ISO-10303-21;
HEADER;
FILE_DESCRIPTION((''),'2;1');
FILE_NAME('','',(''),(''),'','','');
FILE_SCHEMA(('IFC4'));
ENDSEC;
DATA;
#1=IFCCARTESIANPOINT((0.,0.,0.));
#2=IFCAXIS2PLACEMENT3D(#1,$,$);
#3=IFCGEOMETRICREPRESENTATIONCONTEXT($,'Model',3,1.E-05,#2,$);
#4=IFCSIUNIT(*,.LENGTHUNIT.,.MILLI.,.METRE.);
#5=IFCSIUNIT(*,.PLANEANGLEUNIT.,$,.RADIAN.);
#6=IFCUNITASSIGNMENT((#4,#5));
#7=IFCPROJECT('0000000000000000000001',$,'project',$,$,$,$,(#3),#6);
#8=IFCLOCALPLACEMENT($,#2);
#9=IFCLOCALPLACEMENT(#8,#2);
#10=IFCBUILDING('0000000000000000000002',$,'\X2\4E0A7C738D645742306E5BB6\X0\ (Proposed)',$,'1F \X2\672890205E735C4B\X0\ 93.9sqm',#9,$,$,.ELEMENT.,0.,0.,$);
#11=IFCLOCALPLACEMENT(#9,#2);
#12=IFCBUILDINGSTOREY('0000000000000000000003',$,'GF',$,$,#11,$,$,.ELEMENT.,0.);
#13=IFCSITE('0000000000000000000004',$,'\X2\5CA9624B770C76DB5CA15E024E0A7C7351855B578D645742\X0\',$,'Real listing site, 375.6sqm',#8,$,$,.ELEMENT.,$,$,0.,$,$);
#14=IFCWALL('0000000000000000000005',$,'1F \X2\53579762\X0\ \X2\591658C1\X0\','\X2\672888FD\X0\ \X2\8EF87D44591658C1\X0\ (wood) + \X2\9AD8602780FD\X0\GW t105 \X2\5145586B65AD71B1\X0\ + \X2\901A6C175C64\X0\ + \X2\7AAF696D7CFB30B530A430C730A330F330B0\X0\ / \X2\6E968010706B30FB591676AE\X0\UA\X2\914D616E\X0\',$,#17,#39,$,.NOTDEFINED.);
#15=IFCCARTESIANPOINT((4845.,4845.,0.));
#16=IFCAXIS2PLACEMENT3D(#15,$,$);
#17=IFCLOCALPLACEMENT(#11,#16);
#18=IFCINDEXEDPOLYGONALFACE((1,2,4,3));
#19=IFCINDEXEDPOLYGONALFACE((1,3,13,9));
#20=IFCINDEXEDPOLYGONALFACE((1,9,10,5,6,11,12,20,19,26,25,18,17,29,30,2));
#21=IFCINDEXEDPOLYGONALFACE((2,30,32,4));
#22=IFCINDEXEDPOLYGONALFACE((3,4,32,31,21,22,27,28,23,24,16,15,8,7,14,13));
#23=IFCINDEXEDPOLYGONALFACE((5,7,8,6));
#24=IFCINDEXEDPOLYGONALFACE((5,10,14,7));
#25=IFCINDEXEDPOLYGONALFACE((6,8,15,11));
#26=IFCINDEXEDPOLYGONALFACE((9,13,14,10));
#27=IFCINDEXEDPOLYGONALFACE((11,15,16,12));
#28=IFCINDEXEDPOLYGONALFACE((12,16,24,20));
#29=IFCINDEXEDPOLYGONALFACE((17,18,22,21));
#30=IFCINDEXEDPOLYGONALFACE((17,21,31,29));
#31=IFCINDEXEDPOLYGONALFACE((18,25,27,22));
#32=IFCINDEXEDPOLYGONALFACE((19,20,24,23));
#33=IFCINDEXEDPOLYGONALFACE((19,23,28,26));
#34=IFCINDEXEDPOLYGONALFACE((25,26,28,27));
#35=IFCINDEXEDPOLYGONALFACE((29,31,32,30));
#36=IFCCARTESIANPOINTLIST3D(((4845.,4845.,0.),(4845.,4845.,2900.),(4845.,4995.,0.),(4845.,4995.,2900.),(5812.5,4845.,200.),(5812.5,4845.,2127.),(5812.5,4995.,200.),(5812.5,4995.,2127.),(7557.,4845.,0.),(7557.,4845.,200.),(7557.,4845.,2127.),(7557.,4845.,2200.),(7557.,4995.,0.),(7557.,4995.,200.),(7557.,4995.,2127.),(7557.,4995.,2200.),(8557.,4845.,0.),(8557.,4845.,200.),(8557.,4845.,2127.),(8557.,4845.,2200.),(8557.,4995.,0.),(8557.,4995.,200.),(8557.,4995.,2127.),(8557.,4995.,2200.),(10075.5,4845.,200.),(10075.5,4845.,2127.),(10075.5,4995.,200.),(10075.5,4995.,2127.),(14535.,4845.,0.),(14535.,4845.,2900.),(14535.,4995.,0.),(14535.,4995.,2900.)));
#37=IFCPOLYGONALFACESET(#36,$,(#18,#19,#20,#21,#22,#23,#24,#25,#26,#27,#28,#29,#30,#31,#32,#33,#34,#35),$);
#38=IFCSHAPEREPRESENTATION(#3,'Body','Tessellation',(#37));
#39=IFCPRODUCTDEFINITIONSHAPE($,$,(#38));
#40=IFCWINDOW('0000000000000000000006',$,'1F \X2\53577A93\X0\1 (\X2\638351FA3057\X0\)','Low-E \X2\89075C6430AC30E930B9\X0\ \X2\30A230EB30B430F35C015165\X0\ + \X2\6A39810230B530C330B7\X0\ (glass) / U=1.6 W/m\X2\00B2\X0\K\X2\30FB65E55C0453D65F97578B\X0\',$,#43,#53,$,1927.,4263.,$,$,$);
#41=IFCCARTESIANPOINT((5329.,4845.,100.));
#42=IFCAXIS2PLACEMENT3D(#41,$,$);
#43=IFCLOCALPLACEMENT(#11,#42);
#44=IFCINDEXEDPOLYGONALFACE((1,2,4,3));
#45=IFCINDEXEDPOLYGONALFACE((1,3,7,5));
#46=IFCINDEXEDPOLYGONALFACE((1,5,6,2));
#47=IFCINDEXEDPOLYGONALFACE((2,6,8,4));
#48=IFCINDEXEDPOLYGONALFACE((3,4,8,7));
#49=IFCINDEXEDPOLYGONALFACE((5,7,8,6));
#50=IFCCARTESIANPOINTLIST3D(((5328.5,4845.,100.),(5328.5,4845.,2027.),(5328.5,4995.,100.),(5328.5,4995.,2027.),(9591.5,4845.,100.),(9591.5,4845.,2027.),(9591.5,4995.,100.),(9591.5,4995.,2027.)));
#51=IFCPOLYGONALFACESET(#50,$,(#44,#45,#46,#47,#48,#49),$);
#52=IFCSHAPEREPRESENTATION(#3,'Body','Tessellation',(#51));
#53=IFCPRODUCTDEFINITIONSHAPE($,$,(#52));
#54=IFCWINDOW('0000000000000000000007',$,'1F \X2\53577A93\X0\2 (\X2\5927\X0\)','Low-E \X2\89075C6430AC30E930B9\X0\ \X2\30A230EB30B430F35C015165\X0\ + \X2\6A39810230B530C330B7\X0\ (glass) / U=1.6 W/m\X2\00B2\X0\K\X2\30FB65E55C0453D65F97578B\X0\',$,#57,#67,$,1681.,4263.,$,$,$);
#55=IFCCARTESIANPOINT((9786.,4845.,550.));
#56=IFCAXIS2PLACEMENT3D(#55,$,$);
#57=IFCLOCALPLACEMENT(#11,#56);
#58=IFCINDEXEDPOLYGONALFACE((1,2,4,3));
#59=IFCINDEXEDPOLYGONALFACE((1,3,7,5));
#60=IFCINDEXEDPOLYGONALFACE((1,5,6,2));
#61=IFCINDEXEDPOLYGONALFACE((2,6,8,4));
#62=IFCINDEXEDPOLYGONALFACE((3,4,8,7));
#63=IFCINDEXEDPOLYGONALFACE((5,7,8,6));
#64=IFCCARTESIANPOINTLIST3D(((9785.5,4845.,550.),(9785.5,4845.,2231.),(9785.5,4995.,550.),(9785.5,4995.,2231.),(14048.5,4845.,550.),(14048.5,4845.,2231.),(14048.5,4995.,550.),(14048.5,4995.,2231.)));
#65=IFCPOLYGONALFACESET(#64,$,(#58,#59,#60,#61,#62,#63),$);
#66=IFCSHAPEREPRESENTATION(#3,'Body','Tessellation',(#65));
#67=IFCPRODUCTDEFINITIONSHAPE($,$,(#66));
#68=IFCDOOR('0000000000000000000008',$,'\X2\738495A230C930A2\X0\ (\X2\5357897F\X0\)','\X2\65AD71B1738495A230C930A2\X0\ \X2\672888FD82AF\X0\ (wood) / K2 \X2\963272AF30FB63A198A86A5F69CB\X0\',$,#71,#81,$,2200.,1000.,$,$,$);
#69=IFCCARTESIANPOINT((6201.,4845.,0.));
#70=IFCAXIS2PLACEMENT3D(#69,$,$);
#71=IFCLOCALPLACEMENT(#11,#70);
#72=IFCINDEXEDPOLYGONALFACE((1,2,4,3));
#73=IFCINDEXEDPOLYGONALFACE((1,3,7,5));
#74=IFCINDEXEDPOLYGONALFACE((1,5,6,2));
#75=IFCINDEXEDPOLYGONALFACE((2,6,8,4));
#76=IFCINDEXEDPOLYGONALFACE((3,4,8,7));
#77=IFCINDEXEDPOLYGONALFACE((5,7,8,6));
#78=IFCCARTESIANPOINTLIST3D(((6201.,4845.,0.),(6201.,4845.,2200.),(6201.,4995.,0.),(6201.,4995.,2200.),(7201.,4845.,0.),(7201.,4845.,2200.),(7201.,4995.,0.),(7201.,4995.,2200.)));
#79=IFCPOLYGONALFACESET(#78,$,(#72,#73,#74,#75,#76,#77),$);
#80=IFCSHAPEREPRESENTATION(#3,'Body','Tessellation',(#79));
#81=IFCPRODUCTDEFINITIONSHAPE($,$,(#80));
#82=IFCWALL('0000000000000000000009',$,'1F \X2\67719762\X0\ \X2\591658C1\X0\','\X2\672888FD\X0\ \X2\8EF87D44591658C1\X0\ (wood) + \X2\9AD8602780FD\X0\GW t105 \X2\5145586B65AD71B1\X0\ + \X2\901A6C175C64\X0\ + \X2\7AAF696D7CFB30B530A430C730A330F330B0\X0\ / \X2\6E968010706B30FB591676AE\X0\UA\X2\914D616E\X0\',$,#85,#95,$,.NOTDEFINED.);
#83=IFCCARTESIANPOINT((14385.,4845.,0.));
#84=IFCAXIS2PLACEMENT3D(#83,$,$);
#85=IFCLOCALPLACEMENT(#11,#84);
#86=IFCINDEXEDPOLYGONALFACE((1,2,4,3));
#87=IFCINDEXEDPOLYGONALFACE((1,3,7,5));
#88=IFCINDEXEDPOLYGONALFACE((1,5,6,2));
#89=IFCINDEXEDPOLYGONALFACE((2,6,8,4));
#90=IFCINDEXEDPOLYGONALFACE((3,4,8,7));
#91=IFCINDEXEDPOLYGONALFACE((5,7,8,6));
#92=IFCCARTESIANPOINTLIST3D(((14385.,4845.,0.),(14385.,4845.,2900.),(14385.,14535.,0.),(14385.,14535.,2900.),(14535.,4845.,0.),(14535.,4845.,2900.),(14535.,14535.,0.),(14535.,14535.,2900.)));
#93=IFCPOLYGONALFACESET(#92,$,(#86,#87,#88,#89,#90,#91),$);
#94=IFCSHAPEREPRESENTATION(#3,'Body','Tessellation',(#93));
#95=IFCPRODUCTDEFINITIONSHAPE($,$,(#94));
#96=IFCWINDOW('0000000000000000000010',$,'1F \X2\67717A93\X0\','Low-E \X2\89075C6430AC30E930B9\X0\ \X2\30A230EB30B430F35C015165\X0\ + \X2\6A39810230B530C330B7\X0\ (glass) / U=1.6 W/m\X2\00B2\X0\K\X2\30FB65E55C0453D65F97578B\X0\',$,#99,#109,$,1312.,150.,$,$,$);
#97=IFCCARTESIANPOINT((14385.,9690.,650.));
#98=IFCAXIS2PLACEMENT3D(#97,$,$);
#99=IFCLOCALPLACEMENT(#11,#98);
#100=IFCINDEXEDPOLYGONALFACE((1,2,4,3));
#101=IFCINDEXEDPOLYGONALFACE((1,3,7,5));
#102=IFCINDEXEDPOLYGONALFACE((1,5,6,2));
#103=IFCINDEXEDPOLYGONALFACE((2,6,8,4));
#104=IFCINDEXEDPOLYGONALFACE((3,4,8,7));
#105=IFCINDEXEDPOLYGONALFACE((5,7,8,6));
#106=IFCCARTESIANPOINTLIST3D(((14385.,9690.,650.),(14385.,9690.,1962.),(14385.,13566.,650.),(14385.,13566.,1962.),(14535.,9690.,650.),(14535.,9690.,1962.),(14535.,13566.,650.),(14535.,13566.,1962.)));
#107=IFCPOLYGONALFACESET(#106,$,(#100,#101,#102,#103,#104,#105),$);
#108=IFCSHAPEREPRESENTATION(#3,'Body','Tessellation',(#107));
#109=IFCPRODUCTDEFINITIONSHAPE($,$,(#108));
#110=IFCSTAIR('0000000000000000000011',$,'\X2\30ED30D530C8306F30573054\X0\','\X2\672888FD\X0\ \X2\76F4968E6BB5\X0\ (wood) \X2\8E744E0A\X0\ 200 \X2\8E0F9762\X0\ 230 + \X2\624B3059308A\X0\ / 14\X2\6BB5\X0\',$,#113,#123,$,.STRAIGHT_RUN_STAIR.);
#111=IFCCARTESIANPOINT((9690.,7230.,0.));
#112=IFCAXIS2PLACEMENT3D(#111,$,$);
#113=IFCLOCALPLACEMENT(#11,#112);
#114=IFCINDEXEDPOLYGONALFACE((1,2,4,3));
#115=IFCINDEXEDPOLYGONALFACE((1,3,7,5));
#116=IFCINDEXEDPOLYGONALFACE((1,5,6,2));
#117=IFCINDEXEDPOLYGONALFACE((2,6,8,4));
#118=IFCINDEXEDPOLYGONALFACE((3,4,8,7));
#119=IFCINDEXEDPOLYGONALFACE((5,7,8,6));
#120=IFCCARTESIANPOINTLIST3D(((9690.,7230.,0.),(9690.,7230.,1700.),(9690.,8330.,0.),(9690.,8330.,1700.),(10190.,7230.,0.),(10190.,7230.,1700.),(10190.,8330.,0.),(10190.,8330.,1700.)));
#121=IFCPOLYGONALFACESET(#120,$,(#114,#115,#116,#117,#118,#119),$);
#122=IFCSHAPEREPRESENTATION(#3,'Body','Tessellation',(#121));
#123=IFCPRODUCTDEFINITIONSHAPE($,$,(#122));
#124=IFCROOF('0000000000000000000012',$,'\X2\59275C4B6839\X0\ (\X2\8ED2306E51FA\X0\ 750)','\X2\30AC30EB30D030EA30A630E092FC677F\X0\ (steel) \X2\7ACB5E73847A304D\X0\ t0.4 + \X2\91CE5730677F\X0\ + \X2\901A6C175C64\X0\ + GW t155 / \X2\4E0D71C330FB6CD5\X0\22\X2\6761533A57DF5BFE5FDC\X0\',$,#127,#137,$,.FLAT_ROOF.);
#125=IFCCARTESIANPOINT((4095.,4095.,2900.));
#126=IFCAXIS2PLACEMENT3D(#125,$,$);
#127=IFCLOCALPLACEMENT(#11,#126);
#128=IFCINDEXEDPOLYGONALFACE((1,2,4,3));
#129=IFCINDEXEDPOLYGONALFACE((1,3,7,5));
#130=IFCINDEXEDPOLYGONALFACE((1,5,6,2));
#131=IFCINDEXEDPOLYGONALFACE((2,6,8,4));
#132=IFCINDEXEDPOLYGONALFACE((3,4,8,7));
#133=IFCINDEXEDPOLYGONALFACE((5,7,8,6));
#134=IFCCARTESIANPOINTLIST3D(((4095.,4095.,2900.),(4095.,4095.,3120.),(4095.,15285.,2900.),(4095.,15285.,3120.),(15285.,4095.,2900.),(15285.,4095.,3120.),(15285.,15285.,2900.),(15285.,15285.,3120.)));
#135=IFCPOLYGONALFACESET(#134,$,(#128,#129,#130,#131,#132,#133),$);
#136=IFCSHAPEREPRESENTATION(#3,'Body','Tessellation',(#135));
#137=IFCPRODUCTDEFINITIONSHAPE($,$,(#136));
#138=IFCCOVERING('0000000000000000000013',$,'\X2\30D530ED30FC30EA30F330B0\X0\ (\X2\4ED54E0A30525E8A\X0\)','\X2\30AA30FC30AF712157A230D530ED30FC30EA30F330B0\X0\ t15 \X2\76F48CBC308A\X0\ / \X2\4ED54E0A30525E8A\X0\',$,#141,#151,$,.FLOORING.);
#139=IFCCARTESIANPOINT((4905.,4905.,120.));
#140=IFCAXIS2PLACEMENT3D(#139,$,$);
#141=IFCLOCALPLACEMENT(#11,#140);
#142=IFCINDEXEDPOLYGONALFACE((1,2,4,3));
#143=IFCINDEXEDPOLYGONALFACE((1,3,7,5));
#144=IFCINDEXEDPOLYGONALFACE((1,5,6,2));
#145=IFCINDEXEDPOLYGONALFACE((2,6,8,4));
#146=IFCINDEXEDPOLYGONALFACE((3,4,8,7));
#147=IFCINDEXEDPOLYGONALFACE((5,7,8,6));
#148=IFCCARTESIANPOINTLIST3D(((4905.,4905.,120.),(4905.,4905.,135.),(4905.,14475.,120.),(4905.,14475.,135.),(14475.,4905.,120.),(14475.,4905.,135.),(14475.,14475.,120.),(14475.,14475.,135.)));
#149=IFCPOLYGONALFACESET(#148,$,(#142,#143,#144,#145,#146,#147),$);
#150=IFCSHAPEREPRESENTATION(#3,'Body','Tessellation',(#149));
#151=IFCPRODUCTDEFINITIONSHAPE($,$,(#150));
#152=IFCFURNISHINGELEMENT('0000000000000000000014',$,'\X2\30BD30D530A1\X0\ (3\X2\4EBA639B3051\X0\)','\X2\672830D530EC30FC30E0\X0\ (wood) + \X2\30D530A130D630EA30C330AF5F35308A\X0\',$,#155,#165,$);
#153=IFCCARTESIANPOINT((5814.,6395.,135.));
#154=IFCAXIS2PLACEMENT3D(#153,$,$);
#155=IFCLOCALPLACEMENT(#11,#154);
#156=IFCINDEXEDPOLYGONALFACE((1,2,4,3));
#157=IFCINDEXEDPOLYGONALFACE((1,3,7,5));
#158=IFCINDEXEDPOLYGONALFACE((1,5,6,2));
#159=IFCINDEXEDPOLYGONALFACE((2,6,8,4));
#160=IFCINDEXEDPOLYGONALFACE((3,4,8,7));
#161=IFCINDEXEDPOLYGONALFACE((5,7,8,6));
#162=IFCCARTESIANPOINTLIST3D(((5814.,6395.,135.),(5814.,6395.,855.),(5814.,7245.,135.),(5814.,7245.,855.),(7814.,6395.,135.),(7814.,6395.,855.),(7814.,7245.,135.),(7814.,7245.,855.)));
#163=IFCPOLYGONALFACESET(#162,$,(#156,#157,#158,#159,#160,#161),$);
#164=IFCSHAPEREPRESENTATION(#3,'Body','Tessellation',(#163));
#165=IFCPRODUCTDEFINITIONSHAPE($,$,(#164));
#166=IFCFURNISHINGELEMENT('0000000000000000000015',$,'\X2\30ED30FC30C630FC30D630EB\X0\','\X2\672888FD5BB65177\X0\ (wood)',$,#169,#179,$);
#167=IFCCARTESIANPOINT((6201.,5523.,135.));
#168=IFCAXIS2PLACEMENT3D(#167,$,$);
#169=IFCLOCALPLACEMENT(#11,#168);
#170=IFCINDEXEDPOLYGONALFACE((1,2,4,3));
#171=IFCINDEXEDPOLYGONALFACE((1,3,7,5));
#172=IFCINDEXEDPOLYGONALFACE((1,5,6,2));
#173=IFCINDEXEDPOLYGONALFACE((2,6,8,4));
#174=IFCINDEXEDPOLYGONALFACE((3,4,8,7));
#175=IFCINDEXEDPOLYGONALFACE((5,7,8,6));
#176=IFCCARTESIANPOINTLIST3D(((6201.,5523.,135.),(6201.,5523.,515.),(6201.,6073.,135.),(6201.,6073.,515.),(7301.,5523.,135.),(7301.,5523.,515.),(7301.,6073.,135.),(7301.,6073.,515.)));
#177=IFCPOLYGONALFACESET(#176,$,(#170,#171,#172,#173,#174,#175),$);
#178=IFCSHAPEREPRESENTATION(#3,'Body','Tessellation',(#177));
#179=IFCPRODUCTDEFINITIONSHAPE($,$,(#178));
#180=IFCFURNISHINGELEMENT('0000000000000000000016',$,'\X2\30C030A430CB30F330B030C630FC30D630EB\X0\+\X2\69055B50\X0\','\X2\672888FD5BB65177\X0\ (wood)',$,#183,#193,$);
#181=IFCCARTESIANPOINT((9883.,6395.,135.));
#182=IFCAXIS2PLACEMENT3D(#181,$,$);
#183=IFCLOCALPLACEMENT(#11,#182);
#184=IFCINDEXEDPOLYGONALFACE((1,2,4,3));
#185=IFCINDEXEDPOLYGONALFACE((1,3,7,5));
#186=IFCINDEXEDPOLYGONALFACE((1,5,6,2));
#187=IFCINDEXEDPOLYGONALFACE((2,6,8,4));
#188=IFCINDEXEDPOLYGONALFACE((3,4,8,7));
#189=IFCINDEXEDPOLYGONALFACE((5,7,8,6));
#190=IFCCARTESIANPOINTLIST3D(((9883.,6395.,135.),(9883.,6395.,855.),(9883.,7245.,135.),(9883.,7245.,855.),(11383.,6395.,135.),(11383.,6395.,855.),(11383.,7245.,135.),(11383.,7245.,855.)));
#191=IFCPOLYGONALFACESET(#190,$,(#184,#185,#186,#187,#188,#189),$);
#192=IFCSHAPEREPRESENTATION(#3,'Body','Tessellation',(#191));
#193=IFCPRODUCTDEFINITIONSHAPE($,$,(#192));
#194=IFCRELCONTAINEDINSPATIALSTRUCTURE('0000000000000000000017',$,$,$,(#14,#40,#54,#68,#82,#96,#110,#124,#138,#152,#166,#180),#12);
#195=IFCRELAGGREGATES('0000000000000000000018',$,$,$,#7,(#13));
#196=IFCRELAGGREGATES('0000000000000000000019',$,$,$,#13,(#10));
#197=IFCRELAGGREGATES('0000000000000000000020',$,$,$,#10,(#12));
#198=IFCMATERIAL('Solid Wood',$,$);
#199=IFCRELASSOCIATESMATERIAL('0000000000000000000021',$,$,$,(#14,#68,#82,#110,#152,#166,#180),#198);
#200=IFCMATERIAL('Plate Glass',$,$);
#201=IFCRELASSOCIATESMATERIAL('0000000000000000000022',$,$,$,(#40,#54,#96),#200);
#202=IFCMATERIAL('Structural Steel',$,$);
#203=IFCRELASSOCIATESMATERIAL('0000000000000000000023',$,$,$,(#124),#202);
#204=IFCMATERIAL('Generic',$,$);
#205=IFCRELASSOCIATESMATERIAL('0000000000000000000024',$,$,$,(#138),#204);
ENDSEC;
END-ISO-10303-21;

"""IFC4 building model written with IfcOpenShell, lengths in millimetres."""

from ifc_helpers import new_model, si_unit, frame, frame_2d, origin, place, context, project, spatial, rectangle, extrude, material, element, fill, save


model = new_model("IFC4")

# Units and contexts
model_context = context("Model", 3, precision=1e-05, world=origin())
ifc_project = project(units=[si_unit("LENGTHUNIT", "METRE", prefix="MILLI"), si_unit("PLANEANGLEUNIT", "RADIAN")], contexts=[model_context])

# Site, building, storey
site_placement = place(None, origin())
site = spatial("IfcSite", under=ifc_project, at=site_placement, Name="岩手県盛岡市上米内字赤坂", ObjectType="Real listing site, 375.6sqm", CompositionType="ELEMENT", RefElevation=0.0)
building_placement = place(site_placement, origin())
building = spatial("IfcBuilding", under=site, at=building_placement, Name="上米赤坂の家 (Proposed)", ObjectType="1F 木造平屋 93.9sqm", CompositionType="ELEMENT", ElevationOfRefHeight=0.0, ElevationOfTerrain=0.0)
storey_placement = place(building_placement, origin())
storey = spatial("IfcBuildingStorey", under=building, at=storey_placement, Name="GF", CompositionType="ELEMENT", Elevation=0.0)

# Shared definitions
ifc_material_1 = material(Name="Solid Wood")

# Wall, openings, windows, door
wall_1_placement = place(storey_placement, frame((4845.0, 4845.0, 0.0)))
wall_1 = element("IfcWall", 1, at=wall_1_placement, inside=storey, material=ifc_material_1, Name="1F 南面 外壁", Description="木製 軸組外壁 (wood) + 高性能GW t105 充填断熱 + 通気層 + 窯業系サイディング / 準耐火・外皮UA配慮", PredefinedType="NOTDEFINED", context=model_context, shape_type="SweptSolid", body=[
    extrude(rectangle(XDim=9690.0, YDim=150.0, at=frame_2d((4845.0, 75.0))), frame((4845.0, 4845.0, 0.0)), (0.0, 0.0, 1.0), 2900.0),
])
opening_1_placement = place(storey_placement, frame((5329.0, 4845.0, 100.0)))
opening_1 = element("IfcOpeningElement", 2, at=opening_1_placement, cuts=wall_1, PredefinedType="NOTDEFINED", context=model_context, shape_type="SweptSolid", body=[
    extrude(rectangle(XDim=4263.0, YDim=150.0, at=frame_2d((2131.0, 75.0))), frame((5329.0, 4845.0, 100.0)), (0.0, 0.0, 1.0), 1927.0),
])
opening_2_placement = place(storey_placement, frame((9786.0, 4845.0, 550.0)))
opening_2 = element("IfcOpeningElement", 3, at=opening_2_placement, cuts=wall_1, PredefinedType="NOTDEFINED", context=model_context, shape_type="SweptSolid", body=[
    extrude(rectangle(XDim=4263.0, YDim=150.0, at=frame_2d((2131.0, 75.0))), frame((9786.0, 4845.0, 550.0)), (0.0, 0.0, 1.0), 1681.0),
])
opening_3_placement = place(storey_placement, frame((6201.0, 4845.0, 0.0)))
opening_3 = element("IfcOpeningElement", 4, at=opening_3_placement, cuts=wall_1, PredefinedType="NOTDEFINED", context=model_context, shape_type="SweptSolid", body=[
    extrude(rectangle(XDim=1000.0, YDim=150.0, at=frame_2d((500.0, 75.0))), frame((6201.0, 4845.0, 0.0)), (0.0, 0.0, 1.0), 2200.0),
])
ifc_material_2 = material(Name="Plate Glass")
window_1_placement = place(storey_placement, frame((5329.0, 4845.0, 100.0)))
window_1 = element("IfcWindow", 5, at=window_1_placement, inside=storey, material=ifc_material_2, Name="1F 南窓1 (掃出し)", Description="Low-E 複層ガラス アルゴン封入 + 樹脂サッシ (glass) / U=1.6 W/m²K・日射取得型", OverallHeight=1927.0, OverallWidth=4263.0, context=model_context, shape_type="SweptSolid", body=[
    extrude(rectangle(XDim=4263.0, YDim=150.0, at=frame_2d((2131.0, 75.0))), frame((5329.0, 4845.0, 100.0)), (0.0, 0.0, 1.0), 1927.0),
])
fill(opening_1, window_1)
window_2_placement = place(storey_placement, frame((9786.0, 4845.0, 550.0)))
window_2 = element("IfcWindow", 6, at=window_2_placement, inside=storey, material=ifc_material_2, Name="1F 南窓2 (大)", Description="Low-E 複層ガラス アルゴン封入 + 樹脂サッシ (glass) / U=1.6 W/m²K・日射取得型", OverallHeight=1681.0, OverallWidth=4263.0, context=model_context, shape_type="SweptSolid", body=[
    extrude(rectangle(XDim=4263.0, YDim=150.0, at=frame_2d((2131.0, 75.0))), frame((9786.0, 4845.0, 550.0)), (0.0, 0.0, 1.0), 1681.0),
])
fill(opening_2, window_2)
door_placement = place(storey_placement, frame((6201.0, 4845.0, 0.0)))
door = element("IfcDoor", 7, at=door_placement, inside=storey, material=ifc_material_1, Name="玄関ドア (南西)", Description="断熱玄関ドア 木製芯 (wood) / K2 防犯・採風機構", OverallHeight=2200.0, OverallWidth=1000.0, context=model_context, shape_type="SweptSolid", body=[
    extrude(rectangle(XDim=1000.0, YDim=150.0, at=frame_2d((500.0, 75.0))), frame((6201.0, 4845.0, 0.0)), (0.0, 0.0, 1.0), 2200.0),
])
fill(opening_3, door)

# Wall, opening, window
wall_2_placement = place(storey_placement, frame((14385.0, 4845.0, 0.0)))
wall_2 = element("IfcWall", 8, at=wall_2_placement, inside=storey, material=ifc_material_1, Name="1F 東面 外壁", Description="木製 軸組外壁 (wood) + 高性能GW t105 充填断熱 + 通気層 + 窯業系サイディング / 準耐火・外皮UA配慮", PredefinedType="NOTDEFINED", context=model_context, shape_type="SweptSolid", body=[
    extrude(rectangle(XDim=150.0, YDim=9690.0, at=frame_2d((75.0, 4845.0))), frame((14385.0, 4845.0, 0.0)), (0.0, 0.0, 1.0), 2900.0),
])
opening_4_placement = place(storey_placement, frame((14385.0, 9690.0, 650.0)))
opening_4 = element("IfcOpeningElement", 9, at=opening_4_placement, cuts=wall_2, PredefinedType="NOTDEFINED", context=model_context, shape_type="SweptSolid", body=[
    extrude(rectangle(XDim=150.0, YDim=3876.0, at=frame_2d((75.0, 1938.0))), frame((14385.0, 9690.0, 650.0)), (0.0, 0.0, 1.0), 1312.0),
])
window_3_placement = place(storey_placement, frame((14385.0, 9690.0, 650.0)))
window_3 = element("IfcWindow", 10, at=window_3_placement, inside=storey, material=ifc_material_2, Name="1F 東窓", Description="Low-E 複層ガラス アルゴン封入 + 樹脂サッシ (glass) / U=1.6 W/m²K・日射取得型", OverallHeight=1312.0, OverallWidth=150.0, context=model_context, shape_type="SweptSolid", body=[
    extrude(rectangle(XDim=150.0, YDim=3876.0, at=frame_2d((75.0, 1938.0))), frame((14385.0, 9690.0, 650.0)), (0.0, 0.0, 1.0), 1312.0),
])
fill(opening_4, window_3)

# Stair
stair_placement = place(storey_placement, frame((9690.0, 7230.0, 0.0)))
element("IfcStair", 11, at=stair_placement, inside=storey, material=ifc_material_1, Name="ロフトはしご", Description="木製 直階段 (wood) 蹴上 200 踏面 230 + 手すり / 14段", PredefinedType="STRAIGHT_RUN_STAIR", context=model_context, shape_type="SweptSolid", body=[
    extrude(rectangle(XDim=500.0, YDim=1100.0, at=frame_2d((250.0, 550.0))), frame((9690.0, 7230.0, 0.0)), (0.0, 0.0, 1.0), 1700.0),
])

# Roof
ifc_material_3 = material(Name="Structural Steel")
roof_placement = place(storey_placement, frame((4095.0, 4095.0, 2900.0)))
element("IfcRoof", 12, at=roof_placement, inside=storey, material=ifc_material_3, Name="大屋根 (軒の出 750)", Description="ガルバリウム鋼板 (steel) 立平葺き t0.4 + 野地板 + 通気層 + GW t155 / 不燃・法22条区域対応", PredefinedType="FLAT_ROOF", context=model_context, shape_type="SweptSolid", body=[
    extrude(rectangle(XDim=11190.0, YDim=11190.0, at=frame_2d((5595.0, 5595.0))), frame((4095.0, 4095.0, 2900.0)), (0.0, 0.0, 1.0), 220.0),
])

# Covering
ifc_material_4 = material(Name="Generic")
covering_placement = place(storey_placement, frame((4905.0, 4905.0, 120.0)))
element("IfcCovering", 13, at=covering_placement, inside=storey, material=ifc_material_4, Name="フローリング (仕上げ床)", Description="オーク無垢フローリング t15 直貼り / 仕上げ床", PredefinedType="FLOORING", context=model_context, shape_type="SweptSolid", body=[
    extrude(rectangle(XDim=9570.0, YDim=9570.0, at=frame_2d((4785.0, 4785.0))), frame((4905.0, 4905.0, 120.0)), (0.0, 0.0, 1.0), 15.0),
])

# Furnishing elements
furnishing_1_placement = place(storey_placement, frame((5814.0, 6395.0, 135.0)))
element("IfcFurnishingElement", 14, at=furnishing_1_placement, inside=storey, material=ifc_material_1, Name="ソファ (3人掛け)", Description="木フレーム (wood) + ファブリック張り", context=model_context, shape_type="SweptSolid", body=[
    extrude(rectangle(XDim=2000.0, YDim=850.0, at=frame_2d((1000.0, 425.0))), frame((5814.0, 6395.0, 135.0)), (0.0, 0.0, 1.0), 720.0),
])
furnishing_2_placement = place(storey_placement, frame((6201.0, 5523.0, 135.0)))
element("IfcFurnishingElement", 15, at=furnishing_2_placement, inside=storey, material=ifc_material_1, Name="ローテーブル", Description="木製家具 (wood)", context=model_context, shape_type="SweptSolid", body=[
    extrude(rectangle(XDim=1100.0, YDim=550.0, at=frame_2d((550.0, 275.0))), frame((6201.0, 5523.0, 135.0)), (0.0, 0.0, 1.0), 380.0),
])
furnishing_3_placement = place(storey_placement, frame((9883.0, 6395.0, 135.0)))
element("IfcFurnishingElement", 16, at=furnishing_3_placement, inside=storey, material=ifc_material_1, Name="ダイニングテーブル+椅子", Description="木製家具 (wood)", context=model_context, shape_type="SweptSolid", body=[
    extrude(rectangle(XDim=1500.0, YDim=850.0, at=frame_2d((750.0, 425.0))), frame((9883.0, 6395.0, 135.0)), (0.0, 0.0, 1.0), 720.0),
])

save(model, "model.ifc")
